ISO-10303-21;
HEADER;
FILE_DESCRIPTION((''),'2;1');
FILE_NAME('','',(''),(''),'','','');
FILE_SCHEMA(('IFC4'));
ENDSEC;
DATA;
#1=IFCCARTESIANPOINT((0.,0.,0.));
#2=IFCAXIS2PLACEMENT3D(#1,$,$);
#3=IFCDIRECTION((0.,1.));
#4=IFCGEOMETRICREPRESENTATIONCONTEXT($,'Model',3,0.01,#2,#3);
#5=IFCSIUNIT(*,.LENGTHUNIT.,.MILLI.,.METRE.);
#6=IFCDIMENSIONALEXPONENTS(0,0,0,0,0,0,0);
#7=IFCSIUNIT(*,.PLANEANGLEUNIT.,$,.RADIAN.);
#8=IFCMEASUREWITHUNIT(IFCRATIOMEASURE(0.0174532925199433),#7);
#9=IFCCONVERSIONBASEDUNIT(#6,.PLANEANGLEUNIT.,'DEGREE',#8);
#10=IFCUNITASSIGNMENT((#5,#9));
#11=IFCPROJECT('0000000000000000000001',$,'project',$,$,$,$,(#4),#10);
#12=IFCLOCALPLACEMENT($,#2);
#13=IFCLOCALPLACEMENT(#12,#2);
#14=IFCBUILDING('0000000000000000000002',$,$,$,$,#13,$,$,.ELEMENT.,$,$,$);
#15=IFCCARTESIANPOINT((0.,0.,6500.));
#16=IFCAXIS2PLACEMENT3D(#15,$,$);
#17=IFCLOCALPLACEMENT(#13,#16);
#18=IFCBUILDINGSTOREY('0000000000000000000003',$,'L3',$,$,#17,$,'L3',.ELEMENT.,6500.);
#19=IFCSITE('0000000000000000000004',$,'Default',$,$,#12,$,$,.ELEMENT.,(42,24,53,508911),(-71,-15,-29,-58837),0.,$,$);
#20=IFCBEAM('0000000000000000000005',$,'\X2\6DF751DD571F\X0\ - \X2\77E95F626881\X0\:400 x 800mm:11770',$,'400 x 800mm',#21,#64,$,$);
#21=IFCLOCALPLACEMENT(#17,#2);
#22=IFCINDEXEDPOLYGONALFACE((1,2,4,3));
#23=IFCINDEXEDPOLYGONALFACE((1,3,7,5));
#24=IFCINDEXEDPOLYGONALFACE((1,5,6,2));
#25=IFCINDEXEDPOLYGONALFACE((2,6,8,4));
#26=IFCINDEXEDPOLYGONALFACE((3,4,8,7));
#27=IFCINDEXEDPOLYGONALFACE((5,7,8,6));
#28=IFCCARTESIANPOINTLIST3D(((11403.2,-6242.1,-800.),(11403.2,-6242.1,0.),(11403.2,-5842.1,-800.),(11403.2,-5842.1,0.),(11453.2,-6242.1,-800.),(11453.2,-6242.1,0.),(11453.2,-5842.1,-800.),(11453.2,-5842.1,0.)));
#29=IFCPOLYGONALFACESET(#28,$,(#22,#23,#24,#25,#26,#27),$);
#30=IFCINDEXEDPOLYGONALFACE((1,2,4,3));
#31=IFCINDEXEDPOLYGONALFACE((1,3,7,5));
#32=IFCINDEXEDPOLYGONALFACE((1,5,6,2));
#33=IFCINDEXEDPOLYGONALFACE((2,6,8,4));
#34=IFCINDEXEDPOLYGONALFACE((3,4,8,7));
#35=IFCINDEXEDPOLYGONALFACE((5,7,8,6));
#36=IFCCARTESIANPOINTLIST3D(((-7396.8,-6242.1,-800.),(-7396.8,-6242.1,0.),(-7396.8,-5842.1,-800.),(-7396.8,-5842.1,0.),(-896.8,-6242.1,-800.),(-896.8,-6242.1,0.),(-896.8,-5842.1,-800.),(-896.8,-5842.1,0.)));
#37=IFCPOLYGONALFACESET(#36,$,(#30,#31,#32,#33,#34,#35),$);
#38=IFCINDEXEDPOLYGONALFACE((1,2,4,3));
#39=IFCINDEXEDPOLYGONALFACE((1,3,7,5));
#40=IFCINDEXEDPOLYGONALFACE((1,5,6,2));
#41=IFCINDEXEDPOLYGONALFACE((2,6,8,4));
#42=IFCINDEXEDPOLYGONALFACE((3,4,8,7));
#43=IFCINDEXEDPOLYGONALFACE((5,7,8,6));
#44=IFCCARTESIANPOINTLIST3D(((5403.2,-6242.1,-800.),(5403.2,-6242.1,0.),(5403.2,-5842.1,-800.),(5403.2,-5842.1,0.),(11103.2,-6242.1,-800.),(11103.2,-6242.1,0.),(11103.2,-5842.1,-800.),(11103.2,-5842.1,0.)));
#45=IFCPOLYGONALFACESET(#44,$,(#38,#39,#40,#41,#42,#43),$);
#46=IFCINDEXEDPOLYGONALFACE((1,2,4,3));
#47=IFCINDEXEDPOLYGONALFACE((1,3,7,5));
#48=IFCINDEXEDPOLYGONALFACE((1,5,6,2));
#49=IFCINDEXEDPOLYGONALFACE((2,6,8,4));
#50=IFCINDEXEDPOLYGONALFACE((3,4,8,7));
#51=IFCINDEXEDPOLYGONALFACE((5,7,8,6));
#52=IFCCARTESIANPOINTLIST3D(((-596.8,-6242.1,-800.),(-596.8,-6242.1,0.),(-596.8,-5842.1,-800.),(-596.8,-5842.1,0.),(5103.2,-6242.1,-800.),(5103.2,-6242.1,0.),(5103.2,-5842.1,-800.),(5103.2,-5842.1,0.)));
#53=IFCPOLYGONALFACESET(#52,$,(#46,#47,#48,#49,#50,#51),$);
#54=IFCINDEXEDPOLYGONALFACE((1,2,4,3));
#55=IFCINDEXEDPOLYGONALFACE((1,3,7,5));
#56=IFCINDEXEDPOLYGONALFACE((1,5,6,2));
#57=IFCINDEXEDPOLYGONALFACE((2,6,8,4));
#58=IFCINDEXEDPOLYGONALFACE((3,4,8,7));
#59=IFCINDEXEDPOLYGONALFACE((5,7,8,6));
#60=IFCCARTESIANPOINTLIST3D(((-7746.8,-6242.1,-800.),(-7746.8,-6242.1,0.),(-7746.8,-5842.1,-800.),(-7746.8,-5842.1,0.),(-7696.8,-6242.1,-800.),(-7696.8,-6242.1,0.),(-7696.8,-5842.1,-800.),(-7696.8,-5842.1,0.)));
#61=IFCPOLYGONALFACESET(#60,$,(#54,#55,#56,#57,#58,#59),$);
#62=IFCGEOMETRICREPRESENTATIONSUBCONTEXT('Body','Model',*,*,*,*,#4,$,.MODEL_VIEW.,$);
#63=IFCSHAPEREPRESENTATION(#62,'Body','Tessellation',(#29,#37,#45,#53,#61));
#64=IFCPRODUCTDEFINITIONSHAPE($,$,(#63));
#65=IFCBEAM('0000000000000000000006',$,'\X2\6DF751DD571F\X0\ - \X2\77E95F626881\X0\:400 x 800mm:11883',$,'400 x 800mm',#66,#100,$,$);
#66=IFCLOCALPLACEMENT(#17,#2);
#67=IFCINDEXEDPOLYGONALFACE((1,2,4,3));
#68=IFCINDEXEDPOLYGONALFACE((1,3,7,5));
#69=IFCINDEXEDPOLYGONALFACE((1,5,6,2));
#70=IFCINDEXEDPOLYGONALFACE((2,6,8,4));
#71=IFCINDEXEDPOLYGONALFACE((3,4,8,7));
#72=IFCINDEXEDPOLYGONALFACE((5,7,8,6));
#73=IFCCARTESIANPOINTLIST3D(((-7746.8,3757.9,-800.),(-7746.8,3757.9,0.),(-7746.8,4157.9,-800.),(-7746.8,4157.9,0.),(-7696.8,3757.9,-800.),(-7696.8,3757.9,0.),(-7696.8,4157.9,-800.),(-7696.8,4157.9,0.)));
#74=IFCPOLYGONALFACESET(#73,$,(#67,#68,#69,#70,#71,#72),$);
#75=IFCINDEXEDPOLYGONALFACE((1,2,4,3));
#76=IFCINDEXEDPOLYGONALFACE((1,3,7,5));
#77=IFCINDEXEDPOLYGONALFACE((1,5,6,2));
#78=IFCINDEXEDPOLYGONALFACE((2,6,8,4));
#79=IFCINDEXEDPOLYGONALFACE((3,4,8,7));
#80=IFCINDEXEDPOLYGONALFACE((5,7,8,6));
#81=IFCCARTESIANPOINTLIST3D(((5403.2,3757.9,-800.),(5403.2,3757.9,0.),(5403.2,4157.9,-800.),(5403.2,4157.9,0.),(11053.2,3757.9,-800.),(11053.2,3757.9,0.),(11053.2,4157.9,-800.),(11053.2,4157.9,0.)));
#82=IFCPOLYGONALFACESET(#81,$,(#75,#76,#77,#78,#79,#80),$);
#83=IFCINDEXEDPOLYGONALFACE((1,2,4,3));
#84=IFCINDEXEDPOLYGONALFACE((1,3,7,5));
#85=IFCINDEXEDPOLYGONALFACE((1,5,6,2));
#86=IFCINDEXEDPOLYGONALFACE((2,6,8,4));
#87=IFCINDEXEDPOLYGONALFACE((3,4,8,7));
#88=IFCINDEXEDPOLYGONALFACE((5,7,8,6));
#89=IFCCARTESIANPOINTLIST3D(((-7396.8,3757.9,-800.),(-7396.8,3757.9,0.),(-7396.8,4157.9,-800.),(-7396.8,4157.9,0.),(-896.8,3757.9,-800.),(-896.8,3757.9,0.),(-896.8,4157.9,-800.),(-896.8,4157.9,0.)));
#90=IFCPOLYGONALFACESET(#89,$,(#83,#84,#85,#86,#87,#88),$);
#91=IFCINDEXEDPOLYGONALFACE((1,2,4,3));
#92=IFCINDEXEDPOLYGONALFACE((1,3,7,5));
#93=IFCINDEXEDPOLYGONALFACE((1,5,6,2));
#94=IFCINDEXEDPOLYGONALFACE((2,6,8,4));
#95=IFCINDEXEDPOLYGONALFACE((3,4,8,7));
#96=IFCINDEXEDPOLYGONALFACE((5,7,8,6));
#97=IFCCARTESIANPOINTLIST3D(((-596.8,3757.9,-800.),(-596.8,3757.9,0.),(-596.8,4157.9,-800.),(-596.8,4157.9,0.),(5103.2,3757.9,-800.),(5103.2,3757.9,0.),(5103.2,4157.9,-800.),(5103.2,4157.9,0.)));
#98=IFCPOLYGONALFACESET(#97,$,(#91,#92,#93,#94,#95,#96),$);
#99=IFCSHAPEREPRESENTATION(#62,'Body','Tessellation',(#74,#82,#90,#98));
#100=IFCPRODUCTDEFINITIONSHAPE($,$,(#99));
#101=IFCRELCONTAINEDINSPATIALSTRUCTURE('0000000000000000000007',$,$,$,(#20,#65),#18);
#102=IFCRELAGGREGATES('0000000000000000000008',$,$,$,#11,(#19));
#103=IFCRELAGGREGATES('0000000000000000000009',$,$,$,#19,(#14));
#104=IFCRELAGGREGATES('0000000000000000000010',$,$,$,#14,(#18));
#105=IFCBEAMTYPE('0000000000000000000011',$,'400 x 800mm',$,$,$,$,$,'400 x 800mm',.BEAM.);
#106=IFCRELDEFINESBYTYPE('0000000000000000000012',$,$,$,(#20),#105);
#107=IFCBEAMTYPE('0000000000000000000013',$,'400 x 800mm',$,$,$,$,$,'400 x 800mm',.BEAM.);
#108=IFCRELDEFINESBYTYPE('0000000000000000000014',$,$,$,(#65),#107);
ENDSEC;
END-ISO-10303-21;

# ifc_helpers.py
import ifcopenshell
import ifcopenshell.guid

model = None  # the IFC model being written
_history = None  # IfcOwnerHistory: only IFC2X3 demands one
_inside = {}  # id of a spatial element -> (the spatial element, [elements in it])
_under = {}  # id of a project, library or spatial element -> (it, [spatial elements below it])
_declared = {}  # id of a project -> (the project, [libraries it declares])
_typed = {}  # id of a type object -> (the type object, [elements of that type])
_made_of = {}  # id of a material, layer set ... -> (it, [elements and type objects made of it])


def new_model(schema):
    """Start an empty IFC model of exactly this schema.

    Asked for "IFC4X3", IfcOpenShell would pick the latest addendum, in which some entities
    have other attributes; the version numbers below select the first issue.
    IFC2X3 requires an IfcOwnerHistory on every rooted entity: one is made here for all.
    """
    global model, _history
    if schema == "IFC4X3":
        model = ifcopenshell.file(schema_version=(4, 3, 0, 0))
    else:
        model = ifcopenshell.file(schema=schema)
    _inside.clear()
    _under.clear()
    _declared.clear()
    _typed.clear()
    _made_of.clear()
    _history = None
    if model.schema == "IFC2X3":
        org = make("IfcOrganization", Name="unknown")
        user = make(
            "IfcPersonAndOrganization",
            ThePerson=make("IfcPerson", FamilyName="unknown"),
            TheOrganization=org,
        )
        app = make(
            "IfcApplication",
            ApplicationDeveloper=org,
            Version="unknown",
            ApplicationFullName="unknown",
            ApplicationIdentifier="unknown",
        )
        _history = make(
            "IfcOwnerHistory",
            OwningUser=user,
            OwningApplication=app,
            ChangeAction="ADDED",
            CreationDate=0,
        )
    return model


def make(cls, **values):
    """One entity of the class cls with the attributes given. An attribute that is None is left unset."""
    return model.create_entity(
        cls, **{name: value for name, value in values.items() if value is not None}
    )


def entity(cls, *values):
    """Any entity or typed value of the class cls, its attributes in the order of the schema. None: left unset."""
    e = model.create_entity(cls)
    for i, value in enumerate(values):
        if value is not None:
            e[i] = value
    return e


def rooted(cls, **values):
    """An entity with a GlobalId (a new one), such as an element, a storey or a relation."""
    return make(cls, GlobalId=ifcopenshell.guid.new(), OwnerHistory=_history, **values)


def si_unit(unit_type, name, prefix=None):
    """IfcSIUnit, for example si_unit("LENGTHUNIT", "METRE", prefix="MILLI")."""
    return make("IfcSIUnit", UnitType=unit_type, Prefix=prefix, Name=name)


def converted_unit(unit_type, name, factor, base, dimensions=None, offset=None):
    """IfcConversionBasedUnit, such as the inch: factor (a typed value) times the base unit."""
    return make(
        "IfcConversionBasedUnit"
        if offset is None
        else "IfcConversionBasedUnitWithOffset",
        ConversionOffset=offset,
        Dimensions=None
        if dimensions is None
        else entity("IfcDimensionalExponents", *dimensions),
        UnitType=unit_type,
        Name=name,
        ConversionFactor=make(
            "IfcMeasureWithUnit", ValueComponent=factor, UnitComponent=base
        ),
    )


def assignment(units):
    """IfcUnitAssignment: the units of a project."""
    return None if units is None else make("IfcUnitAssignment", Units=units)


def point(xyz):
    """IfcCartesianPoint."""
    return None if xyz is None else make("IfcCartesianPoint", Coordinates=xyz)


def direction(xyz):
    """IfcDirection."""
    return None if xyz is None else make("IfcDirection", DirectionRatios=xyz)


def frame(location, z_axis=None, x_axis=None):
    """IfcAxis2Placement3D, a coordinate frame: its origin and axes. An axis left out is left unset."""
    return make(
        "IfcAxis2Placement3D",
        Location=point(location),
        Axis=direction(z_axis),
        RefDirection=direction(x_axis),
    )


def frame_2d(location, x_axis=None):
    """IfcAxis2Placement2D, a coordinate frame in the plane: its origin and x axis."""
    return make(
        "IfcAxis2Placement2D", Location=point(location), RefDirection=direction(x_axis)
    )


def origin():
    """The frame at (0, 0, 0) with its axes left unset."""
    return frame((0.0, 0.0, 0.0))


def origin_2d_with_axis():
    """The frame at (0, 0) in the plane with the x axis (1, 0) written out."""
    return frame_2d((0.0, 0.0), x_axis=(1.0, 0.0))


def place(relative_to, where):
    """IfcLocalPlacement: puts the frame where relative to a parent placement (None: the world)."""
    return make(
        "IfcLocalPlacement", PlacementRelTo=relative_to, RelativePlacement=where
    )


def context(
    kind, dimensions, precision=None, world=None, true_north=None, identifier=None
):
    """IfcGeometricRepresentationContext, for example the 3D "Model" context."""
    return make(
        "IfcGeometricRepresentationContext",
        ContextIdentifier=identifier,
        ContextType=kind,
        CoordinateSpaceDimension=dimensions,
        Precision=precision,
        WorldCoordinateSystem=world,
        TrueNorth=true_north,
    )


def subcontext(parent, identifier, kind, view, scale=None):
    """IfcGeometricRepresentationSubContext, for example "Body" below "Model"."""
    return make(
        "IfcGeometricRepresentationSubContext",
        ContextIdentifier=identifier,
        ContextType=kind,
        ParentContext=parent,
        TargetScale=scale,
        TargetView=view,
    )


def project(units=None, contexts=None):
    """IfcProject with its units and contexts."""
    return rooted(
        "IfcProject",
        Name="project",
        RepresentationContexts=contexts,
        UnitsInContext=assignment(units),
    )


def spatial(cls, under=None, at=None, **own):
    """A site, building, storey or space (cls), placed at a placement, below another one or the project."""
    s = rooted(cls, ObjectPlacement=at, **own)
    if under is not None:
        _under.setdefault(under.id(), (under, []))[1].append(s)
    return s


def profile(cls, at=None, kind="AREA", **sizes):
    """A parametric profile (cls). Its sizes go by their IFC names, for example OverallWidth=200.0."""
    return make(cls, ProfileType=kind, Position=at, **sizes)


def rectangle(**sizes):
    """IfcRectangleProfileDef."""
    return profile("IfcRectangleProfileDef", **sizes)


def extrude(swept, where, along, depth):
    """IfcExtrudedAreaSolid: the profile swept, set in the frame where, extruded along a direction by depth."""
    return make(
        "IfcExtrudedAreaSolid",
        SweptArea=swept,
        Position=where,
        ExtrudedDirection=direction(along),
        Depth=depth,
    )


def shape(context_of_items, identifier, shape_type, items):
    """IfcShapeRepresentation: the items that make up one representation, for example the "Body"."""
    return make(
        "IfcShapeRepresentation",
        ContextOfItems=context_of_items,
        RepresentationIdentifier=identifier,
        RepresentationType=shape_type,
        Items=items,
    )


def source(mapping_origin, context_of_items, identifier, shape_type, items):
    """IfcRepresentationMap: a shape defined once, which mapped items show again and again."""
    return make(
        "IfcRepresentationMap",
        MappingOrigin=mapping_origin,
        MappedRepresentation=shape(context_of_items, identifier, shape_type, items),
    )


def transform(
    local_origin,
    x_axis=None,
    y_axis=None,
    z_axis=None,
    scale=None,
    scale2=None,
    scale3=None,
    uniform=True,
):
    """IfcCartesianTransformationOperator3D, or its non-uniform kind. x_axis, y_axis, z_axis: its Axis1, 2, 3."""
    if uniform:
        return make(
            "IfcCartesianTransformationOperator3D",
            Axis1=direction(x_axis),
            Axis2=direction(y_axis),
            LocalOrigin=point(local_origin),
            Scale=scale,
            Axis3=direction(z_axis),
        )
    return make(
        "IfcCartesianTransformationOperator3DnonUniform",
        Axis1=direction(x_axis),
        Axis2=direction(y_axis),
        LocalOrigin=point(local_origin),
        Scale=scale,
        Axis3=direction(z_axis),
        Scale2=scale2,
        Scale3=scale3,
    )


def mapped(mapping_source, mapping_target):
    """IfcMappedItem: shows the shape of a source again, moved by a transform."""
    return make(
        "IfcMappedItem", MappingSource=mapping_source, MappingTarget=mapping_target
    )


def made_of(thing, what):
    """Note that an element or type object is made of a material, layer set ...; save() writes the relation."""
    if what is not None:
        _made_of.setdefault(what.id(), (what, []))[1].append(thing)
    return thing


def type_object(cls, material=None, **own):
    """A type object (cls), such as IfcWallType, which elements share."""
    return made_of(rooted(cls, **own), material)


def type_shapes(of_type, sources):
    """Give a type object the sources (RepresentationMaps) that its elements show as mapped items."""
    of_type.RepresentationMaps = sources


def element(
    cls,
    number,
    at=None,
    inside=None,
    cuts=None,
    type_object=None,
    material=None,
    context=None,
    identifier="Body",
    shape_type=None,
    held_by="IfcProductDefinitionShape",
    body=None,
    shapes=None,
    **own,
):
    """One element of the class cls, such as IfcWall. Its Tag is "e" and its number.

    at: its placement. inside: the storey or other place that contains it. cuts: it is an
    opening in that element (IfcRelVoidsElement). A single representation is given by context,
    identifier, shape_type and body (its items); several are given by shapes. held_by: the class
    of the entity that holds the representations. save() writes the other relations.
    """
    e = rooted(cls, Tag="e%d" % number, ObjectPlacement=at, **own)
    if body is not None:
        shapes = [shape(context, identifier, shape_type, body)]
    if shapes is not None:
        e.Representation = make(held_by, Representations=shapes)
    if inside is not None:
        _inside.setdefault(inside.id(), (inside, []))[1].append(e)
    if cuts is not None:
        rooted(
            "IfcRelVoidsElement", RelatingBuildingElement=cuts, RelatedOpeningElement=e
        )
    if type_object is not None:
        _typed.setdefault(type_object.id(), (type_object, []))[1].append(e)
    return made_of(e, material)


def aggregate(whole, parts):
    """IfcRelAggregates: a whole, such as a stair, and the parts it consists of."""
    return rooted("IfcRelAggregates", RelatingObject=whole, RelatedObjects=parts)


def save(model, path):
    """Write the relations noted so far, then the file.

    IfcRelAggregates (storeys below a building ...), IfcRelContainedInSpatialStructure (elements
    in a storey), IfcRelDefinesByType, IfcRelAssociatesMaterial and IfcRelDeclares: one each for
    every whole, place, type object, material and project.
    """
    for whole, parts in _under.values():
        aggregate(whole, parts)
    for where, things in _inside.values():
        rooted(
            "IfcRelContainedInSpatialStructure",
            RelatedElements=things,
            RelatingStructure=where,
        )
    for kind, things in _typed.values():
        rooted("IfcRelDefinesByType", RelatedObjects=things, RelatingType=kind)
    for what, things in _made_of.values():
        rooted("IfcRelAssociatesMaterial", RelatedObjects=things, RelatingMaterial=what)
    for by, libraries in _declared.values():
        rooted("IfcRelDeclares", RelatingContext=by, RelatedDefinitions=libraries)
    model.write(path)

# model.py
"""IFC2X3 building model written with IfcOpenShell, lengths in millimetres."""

from ifc_helpers import new_model, entity, si_unit, converted_unit, direction, frame, frame_2d, origin, origin_2d_with_axis, place, context, subcontext, project, spatial, rectangle, extrude, source, transform, mapped, type_object, type_shapes, element, save


model = new_model("IFC2X3")

# Units and contexts
model_context = context("Model", 3, precision=0.01, world=origin(), true_north=direction((0.0, 1.0)))
body_context = subcontext(model_context, "Body", "Model", "MODEL_VIEW")
ifc_project = project(units=[si_unit("LENGTHUNIT", "METRE", prefix="MILLI"), converted_unit("PLANEANGLEUNIT", "DEGREE", entity("IfcRatioMeasure", 0.0174532925199433), si_unit("PLANEANGLEUNIT", "RADIAN"), dimensions=[0, 0, 0, 0, 0, 0, 0])], contexts=[model_context])

# Site, building, storey
site_placement = place(None, origin())
site = spatial("IfcSite", under=ifc_project, at=site_placement, Name="Default", CompositionType="ELEMENT", RefLatitude=(42, 24, 53, 508911), RefLongitude=(-71, -15, -29, -58837), RefElevation=0.0)
building_placement = place(site_placement, origin())
building = spatial("IfcBuilding", under=site, at=building_placement, CompositionType="ELEMENT")
storey_placement = place(building_placement, frame((0.0, 0.0, 6500.0)))
storey = spatial("IfcBuildingStorey", under=building, at=storey_placement, Name="L3", LongName="L3", CompositionType="ELEMENT", Elevation=6500.0)

# Beams
beam_type_1 = type_object("IfcBeamType", Name="400 x 800mm", ElementType="400 x 800mm", PredefinedType="BEAM")
shared_shape_1 = source(origin(), body_context, "Body", "SweptSolid", [
    extrude(rectangle(XDim=50.0, YDim=400.0, at=frame_2d((0.0, 0.0), x_axis=(1.0, 0.0))), frame((11428.2, -6042.1, 5700.0), z_axis=(0.0, 0.0, 1.0), x_axis=(-1.0, 0.0, 0.0)), (0.0, 0.0, 1.0), 800.0),
    extrude(rectangle(XDim=6500.0, YDim=400.0, at=frame_2d((640.0, -40.0), x_axis=(1.0, 0.0))), frame((-4786.8, -6002.1, 5700.0)), (0.0, 0.0, 1.0), 800.0),
    extrude(rectangle(XDim=5700.0, YDim=400.0, at=frame_2d((560.0, 40.0), x_axis=(1.0, 0.0))), frame((8813.2, -6002.1, 5700.0), z_axis=(0.0, 0.0, 1.0), x_axis=(-1.0, 0.0, 0.0)), (0.0, 0.0, 1.0), 800.0),
    extrude(rectangle(XDim=5700.0, YDim=400.0, at=origin_2d_with_axis()), frame((2253.2, -6042.1, 5700.0), z_axis=(0.0, 0.0, 1.0), x_axis=(-1.0, 0.0, 0.0)), (0.0, 0.0, 1.0), 800.0),
    extrude(rectangle(XDim=50.0, YDim=400.0, at=frame_2d((0.0, 0.0), x_axis=(1.0, 0.0))), frame((-7721.8, -6042.1, 5700.0)), (0.0, 0.0, 1.0), 800.0),
])
type_shapes(beam_type_1, [shared_shape_1])
beam_1_placement = place(storey_placement, frame((0.0, 0.0, -6500.0)))
element("IfcBeam", 1, at=beam_1_placement, inside=storey, type_object=beam_type_1, Name="混凝土 - 矩形梁:400 x 800mm:11770", ObjectType="400 x 800mm", context=body_context, shape_type="MappedRepresentation", body=[
    mapped(shared_shape_1, transform((0.0, 0.0, 0.0), scale=1.0)),
])
beam_type_2 = type_object("IfcBeamType", Name="400 x 800mm", ElementType="400 x 800mm", PredefinedType="BEAM")
shared_shape_2 = source(origin(), body_context, "Body", "SweptSolid", [
    extrude(rectangle(XDim=50.0, YDim=400.0, at=frame_2d((0.0, 0.0), x_axis=(1.0, 0.0))), frame((-7721.8, 3957.9, 5700.0)), (0.0, 0.0, 1.0), 800.0),
    extrude(rectangle(XDim=5650.0, YDim=400.0, at=frame_2d((0.0, 0.0), x_axis=(1.0, 0.0))), frame((8228.2, 3957.9, 5700.0), z_axis=(0.0, 0.0, 1.0), x_axis=(-1.0, 0.0, 0.0)), (0.0, 0.0, 1.0), 800.0),
    extrude(rectangle(XDim=6500.0, YDim=400.0, at=frame_2d((640.0, 40.0), x_axis=(1.0, 0.0))), frame((-4786.8, 3917.9, 5700.0)), (0.0, 0.0, 1.0), 800.0),
    extrude(rectangle(XDim=5700.0, YDim=400.0, at=origin_2d_with_axis()), frame((2253.2, 3957.9, 5700.0)), (0.0, 0.0, 1.0), 800.0),
])
type_shapes(beam_type_2, [shared_shape_2])
beam_2_placement = place(storey_placement, frame((0.0, 0.0, -6500.0)))
element("IfcBeam", 2, at=beam_2_placement, inside=storey, type_object=beam_type_2, Name="混凝土 - 矩形梁:400 x 800mm:11883", ObjectType="400 x 800mm", context=body_context, shape_type="MappedRepresentation", body=[
    mapped(shared_shape_2, transform((0.0, 0.0, 0.0), scale=1.0)),
])

save(model, "model.ifc")
